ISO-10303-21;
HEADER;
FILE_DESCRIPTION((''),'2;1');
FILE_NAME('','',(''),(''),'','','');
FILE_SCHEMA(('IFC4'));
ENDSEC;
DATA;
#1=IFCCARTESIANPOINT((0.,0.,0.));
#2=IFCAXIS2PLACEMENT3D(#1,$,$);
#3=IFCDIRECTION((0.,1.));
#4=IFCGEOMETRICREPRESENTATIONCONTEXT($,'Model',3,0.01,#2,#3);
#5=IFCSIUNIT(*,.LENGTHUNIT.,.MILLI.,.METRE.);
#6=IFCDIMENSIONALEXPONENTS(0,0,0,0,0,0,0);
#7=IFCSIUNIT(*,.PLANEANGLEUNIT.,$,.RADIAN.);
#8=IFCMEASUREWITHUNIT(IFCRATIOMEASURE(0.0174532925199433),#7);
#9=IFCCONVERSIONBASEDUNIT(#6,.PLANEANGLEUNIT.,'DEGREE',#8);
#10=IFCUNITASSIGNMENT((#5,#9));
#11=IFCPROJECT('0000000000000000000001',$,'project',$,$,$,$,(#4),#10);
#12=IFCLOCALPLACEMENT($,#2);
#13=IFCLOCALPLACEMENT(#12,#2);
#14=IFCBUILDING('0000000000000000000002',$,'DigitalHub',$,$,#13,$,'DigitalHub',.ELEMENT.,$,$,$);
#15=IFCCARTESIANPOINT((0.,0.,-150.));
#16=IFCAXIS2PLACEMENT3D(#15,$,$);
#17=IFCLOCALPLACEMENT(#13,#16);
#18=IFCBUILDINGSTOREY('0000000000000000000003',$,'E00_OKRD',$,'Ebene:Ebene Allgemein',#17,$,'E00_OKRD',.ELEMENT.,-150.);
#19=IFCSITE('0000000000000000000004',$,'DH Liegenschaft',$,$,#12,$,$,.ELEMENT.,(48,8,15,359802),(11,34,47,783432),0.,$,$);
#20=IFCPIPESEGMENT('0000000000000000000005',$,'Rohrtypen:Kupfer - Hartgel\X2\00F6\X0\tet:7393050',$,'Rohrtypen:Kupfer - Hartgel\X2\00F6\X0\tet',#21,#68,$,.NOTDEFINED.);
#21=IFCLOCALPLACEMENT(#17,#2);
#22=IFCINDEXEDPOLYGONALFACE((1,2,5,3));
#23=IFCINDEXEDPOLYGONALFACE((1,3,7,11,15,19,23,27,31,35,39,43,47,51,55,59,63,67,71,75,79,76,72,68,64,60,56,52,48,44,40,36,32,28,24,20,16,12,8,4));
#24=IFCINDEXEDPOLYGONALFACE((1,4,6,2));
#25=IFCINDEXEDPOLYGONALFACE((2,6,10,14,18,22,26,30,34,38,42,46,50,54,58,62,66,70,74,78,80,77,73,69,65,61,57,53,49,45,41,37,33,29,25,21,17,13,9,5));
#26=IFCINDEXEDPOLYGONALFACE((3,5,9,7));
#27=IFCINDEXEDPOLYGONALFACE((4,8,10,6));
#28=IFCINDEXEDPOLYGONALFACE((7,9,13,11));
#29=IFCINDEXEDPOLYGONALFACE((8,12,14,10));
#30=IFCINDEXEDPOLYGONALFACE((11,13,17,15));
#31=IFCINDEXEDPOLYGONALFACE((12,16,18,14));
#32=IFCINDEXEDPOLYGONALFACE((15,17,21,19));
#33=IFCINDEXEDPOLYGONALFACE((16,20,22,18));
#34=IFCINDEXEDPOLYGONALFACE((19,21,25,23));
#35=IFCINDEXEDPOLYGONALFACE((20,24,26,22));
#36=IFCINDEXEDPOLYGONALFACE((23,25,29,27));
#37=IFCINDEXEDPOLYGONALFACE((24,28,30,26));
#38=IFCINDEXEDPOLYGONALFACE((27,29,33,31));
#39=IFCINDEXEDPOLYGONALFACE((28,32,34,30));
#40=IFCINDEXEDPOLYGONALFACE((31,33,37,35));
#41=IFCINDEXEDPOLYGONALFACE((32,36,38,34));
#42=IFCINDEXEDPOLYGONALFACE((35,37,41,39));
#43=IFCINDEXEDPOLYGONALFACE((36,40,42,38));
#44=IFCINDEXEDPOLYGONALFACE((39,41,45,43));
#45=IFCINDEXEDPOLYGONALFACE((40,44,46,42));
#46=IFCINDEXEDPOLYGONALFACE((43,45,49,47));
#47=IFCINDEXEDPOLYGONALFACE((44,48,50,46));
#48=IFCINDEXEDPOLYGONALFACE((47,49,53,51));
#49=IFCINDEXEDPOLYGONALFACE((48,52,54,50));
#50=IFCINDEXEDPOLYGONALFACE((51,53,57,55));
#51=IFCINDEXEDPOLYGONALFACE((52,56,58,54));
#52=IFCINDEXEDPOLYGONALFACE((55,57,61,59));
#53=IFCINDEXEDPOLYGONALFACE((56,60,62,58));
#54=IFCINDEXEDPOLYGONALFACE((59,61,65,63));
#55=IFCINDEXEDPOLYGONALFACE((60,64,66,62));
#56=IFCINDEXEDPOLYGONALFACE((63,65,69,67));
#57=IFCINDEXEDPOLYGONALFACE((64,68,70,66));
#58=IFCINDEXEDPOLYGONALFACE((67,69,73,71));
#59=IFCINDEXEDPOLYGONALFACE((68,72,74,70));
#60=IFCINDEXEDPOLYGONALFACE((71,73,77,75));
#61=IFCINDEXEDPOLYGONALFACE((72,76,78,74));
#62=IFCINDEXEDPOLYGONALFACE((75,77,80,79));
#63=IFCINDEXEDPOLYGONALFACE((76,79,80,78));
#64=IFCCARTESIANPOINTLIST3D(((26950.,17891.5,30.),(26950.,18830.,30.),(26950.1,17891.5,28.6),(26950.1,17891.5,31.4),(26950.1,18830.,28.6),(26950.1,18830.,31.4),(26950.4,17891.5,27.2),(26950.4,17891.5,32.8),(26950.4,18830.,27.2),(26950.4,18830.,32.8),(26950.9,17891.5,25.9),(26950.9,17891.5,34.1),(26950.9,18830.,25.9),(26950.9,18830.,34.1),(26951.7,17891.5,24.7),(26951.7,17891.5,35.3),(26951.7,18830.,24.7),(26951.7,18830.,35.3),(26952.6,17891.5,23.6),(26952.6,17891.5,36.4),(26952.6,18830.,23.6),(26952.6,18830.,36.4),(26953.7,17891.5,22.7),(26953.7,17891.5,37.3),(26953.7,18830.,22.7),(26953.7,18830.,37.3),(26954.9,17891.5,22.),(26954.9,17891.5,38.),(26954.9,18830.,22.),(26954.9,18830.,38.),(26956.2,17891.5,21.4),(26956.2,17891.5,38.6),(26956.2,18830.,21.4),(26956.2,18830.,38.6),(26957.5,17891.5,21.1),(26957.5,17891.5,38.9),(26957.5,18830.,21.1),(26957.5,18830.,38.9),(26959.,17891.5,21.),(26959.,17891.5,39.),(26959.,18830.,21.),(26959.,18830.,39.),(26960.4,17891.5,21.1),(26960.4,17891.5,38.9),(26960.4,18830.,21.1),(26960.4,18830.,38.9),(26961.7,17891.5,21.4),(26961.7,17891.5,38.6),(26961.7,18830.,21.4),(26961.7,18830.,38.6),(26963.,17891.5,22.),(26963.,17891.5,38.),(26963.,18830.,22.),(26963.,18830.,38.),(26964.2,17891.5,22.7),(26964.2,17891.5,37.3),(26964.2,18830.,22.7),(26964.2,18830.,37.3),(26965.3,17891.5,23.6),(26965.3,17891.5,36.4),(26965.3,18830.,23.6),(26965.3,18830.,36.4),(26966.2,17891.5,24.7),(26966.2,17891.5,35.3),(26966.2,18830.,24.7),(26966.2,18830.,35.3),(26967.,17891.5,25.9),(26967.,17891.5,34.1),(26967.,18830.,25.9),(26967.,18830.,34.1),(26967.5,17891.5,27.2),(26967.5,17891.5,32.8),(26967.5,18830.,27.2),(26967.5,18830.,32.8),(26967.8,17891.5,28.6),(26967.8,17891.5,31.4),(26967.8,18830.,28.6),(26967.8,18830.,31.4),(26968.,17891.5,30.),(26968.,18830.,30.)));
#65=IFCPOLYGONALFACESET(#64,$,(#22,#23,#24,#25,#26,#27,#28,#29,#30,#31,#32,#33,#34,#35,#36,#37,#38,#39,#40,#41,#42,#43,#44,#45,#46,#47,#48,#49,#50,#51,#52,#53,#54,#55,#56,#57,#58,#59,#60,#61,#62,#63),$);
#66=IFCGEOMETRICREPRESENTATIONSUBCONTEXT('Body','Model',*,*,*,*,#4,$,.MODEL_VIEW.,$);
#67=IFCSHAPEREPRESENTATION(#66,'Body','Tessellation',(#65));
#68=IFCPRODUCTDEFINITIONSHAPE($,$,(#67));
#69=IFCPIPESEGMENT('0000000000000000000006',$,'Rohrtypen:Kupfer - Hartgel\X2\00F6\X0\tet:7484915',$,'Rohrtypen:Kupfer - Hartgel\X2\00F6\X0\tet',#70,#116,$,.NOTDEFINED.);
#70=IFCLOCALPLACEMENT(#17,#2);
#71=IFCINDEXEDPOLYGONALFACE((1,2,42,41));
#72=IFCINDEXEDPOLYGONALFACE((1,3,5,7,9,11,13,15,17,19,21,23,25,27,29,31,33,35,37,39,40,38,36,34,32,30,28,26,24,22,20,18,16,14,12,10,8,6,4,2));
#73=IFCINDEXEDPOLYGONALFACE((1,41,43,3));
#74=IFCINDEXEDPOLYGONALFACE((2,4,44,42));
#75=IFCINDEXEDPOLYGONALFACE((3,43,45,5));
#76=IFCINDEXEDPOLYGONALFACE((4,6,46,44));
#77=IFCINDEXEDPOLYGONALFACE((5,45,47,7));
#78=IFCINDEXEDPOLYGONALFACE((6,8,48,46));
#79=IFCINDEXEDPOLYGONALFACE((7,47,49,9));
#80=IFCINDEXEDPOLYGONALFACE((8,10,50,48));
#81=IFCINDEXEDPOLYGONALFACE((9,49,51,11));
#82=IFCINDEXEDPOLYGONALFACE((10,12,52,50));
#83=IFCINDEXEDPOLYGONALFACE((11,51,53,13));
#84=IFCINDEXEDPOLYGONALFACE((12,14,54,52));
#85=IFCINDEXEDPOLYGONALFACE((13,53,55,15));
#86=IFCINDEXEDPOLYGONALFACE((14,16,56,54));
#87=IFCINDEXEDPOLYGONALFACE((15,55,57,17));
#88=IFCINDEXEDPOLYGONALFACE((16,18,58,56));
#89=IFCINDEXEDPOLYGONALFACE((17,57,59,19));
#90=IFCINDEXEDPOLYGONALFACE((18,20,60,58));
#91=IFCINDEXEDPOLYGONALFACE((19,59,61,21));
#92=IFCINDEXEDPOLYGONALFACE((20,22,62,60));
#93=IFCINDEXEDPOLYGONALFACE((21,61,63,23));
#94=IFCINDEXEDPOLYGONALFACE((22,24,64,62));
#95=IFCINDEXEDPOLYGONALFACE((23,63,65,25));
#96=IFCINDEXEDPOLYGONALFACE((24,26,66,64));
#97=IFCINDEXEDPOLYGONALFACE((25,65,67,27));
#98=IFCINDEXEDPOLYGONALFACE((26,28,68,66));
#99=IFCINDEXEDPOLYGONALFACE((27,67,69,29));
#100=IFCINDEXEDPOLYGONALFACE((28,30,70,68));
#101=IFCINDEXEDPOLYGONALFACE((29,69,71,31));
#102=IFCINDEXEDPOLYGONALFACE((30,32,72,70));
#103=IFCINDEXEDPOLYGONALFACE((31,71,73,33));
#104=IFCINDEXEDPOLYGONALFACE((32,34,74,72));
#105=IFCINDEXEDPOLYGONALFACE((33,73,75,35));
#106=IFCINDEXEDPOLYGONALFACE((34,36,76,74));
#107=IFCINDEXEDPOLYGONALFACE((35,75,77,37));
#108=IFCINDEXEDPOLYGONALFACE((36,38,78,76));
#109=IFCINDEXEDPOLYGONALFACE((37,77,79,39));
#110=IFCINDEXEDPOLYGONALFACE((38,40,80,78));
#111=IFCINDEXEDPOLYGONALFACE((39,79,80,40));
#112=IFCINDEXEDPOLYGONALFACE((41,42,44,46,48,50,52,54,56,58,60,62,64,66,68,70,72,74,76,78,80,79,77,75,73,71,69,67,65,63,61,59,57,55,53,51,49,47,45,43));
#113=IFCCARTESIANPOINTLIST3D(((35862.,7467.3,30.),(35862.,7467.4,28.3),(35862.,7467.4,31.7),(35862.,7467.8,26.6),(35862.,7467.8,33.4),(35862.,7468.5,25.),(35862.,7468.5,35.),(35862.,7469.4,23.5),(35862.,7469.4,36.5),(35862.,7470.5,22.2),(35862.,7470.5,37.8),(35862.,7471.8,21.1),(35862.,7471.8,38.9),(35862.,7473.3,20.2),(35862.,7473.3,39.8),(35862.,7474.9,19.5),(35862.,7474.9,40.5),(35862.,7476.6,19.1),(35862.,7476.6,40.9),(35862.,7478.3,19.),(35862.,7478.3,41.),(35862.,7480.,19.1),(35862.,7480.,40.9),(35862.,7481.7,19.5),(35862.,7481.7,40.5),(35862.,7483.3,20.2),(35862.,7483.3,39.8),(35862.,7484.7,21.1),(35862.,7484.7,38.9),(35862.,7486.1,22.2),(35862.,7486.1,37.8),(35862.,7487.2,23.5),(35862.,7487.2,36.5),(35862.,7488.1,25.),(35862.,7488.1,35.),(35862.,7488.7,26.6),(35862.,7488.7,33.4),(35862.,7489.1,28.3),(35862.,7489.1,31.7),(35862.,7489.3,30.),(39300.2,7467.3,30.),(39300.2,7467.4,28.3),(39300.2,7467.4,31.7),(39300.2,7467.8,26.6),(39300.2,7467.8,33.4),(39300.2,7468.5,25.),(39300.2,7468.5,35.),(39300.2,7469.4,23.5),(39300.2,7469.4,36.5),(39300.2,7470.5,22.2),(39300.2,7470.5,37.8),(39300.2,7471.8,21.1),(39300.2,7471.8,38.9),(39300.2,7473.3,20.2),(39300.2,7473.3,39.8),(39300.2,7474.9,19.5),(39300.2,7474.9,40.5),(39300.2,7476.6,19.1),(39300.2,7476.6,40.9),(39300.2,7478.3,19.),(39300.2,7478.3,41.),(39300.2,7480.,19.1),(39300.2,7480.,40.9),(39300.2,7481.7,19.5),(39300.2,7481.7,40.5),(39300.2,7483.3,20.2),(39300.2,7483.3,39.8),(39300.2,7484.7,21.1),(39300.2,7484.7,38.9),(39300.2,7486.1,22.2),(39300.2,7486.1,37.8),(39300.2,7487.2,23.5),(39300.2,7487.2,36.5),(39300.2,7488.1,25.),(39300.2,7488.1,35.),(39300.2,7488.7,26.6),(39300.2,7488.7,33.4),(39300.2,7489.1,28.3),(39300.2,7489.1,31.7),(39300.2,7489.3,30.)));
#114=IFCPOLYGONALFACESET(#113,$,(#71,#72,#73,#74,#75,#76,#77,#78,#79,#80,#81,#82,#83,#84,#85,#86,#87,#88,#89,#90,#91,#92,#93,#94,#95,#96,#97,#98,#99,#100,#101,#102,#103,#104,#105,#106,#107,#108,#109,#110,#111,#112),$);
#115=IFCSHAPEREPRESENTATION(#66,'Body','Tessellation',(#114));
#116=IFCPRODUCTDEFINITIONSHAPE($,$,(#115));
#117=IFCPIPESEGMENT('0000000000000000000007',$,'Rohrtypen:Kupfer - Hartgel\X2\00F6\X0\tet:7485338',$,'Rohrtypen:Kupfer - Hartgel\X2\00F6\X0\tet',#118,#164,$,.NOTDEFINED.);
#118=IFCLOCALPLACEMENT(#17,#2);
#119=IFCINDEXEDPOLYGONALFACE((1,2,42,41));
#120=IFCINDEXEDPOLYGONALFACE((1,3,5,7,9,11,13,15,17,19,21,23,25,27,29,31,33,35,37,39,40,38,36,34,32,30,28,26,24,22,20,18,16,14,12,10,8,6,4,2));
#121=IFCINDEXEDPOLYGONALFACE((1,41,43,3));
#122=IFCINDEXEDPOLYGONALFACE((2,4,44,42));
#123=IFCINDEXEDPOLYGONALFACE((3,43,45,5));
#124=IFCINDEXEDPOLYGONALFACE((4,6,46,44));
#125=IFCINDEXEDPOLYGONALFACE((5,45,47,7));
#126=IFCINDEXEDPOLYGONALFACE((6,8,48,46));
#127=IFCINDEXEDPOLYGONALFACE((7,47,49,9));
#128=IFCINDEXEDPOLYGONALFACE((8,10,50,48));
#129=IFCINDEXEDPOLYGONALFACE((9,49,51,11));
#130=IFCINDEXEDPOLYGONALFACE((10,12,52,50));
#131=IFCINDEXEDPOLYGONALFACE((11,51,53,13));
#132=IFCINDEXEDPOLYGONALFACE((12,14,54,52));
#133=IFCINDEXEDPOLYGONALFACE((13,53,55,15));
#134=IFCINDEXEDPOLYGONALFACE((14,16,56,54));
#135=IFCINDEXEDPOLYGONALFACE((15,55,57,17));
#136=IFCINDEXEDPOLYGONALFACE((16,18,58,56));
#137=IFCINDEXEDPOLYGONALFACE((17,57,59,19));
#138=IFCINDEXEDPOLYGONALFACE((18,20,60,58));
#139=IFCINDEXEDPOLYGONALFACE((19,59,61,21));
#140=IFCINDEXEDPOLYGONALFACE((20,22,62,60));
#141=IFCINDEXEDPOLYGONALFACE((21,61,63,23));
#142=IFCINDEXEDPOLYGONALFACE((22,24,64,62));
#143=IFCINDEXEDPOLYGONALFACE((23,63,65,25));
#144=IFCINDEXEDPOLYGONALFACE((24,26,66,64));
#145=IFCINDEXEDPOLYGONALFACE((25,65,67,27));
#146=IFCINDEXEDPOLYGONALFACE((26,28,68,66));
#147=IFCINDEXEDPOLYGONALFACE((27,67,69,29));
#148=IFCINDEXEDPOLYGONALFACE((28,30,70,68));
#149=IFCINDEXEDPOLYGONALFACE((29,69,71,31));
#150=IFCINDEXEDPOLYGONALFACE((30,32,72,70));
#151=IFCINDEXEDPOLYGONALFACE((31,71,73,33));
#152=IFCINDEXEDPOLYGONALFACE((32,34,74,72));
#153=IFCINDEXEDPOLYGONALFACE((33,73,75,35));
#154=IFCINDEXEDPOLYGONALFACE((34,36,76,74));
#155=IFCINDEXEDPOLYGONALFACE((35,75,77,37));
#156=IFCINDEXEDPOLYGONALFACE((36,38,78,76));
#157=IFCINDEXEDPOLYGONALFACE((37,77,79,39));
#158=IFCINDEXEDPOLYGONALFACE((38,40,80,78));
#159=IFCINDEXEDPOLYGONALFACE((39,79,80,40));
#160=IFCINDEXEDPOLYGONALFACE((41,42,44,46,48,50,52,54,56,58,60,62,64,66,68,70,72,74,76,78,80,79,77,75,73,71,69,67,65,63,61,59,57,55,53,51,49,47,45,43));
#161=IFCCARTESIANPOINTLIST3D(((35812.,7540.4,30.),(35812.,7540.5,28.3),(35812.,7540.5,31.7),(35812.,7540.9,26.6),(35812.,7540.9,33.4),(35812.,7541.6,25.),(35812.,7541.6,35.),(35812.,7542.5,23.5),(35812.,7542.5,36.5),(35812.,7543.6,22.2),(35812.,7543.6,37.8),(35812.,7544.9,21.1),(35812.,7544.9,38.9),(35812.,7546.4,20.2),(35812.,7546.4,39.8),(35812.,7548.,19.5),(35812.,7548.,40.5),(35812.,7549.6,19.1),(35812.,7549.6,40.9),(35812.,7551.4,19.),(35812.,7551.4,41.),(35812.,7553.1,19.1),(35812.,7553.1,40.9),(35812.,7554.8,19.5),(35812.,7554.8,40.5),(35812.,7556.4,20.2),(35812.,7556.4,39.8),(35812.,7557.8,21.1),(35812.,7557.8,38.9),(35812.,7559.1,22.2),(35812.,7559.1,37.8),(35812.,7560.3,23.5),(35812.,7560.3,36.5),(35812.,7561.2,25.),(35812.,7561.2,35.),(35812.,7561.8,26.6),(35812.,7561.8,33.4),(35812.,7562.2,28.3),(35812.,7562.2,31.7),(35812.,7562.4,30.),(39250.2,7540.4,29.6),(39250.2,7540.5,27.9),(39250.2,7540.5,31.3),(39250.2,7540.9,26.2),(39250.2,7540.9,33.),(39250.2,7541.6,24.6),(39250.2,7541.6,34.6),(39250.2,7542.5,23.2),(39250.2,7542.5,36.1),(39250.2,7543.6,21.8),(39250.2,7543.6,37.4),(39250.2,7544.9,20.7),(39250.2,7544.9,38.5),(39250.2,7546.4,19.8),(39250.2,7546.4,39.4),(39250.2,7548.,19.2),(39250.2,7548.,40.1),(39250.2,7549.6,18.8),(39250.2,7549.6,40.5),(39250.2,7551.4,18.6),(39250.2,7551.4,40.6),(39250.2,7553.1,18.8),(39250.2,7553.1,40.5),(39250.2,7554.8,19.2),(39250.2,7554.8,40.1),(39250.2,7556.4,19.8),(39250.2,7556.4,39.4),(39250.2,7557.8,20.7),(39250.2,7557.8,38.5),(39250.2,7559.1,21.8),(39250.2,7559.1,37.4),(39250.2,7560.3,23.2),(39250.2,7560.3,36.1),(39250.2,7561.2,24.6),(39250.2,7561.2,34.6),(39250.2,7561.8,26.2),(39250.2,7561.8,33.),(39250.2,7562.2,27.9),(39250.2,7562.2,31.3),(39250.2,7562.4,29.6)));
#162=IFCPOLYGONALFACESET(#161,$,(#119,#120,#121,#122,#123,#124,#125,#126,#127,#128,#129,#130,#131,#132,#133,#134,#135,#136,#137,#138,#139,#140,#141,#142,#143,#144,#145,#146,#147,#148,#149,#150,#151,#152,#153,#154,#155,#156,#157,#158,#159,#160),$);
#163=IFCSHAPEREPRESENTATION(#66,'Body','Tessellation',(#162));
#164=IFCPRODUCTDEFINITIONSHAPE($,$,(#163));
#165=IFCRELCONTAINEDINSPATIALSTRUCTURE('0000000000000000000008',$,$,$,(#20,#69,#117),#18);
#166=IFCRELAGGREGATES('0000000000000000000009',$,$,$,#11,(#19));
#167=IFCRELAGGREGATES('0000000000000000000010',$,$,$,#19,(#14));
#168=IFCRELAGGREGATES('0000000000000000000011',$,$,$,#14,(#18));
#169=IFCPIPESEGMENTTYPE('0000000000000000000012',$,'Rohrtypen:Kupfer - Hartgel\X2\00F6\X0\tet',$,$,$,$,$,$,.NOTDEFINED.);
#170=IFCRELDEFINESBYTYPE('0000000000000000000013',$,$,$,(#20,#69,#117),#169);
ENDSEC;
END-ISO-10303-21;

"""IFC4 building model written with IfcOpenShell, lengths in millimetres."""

from ifc_helpers import new_model, entity, si_unit, converted_unit, direction, frame, origin, place, context, subcontext, project, spatial, indexed_curve, outline, extrude, type_object, element, save


model = new_model("IFC4")

# Units and contexts
model_context = context("Model", 3, precision=0.01, world=origin(), true_north=direction((0.0, 1.0)))
body_context = subcontext(model_context, "Body", "Model", "MODEL_VIEW")
ifc_project = project(units=[si_unit("LENGTHUNIT", "METRE", prefix="MILLI"), converted_unit("PLANEANGLEUNIT", "DEGREE", entity("IfcRatioMeasure", 0.0174532925199433), si_unit("PLANEANGLEUNIT", "RADIAN"), dimensions=[0, 0, 0, 0, 0, 0, 0])], contexts=[model_context])

# Site, building, storey
site_placement = place(None, origin())
site = spatial("IfcSite", under=ifc_project, at=site_placement, Name="DH Liegenschaft", CompositionType="ELEMENT", RefLatitude=(48, 8, 15, 359802), RefLongitude=(11, 34, 47, 783432), RefElevation=0.0)
building_placement = place(site_placement, origin())
building = spatial("IfcBuilding", under=site, at=building_placement, Name="DigitalHub", LongName="DigitalHub", CompositionType="ELEMENT")
storey_placement = place(building_placement, frame((0.0, 0.0, -150.0)))
storey = spatial("IfcBuildingStorey", under=building, at=storey_placement, Name="E00_OKRD", ObjectType="Ebene:Ebene Allgemein", LongName="E00_OKRD", CompositionType="ELEMENT", Elevation=-150.0)

# Pipe segments
pipe_segment_type = type_object("IfcPipeSegmentType", Name="Rohrtypen:Kupfer - Hartgelötet", PredefinedType="NOTDEFINED")
pipe_segment_1_placement = place(storey_placement, frame((26948.4, 17891.5, 19.4)))
element("IfcPipeSegment", 1, at=pipe_segment_1_placement, inside=storey, type_object=pipe_segment_type, Name="Rohrtypen:Kupfer - Hartgelötet:7393050", ObjectType="Rohrtypen:Kupfer - Hartgelötet", PredefinedType="NOTDEFINED", context=body_context, shape_type="SweptSolid", body=[
    extrude(outline(indexed_curve([(9.0, 0.0), (8.9, 1.4), (8.6, 2.8), (8.0, 4.1), (7.3, 5.3), (6.4, 6.4), (5.3, 7.3), (4.1, 8.0), (2.8, 8.6), (1.4, 8.9), (0.0, 9.0), (-1.4, 8.9), (-2.8, 8.6), (-4.1, 8.0), (-5.3, 7.3), (-6.4, 6.4), (-7.3, 5.3), (-8.0, 4.1), (-8.6, 2.8), (-8.9, 1.4), (-9.0, 0.0), (-8.9, -1.4), (-8.6, -2.8), (-8.0, -4.1), (-7.3, -5.3), (-6.4, -6.4), (-5.3, -7.3), (-4.1, -8.0), (-2.8, -8.6), (-1.4, -8.9), (0.0, -9.0), (1.4, -8.9), (2.8, -8.6), (4.1, -8.0), (5.3, -7.3), (6.4, -6.4), (7.3, -5.3), (8.0, -4.1), (8.6, -2.8), (8.9, -1.4), (9.0, 0.0)], self_intersect=False)), frame((10.6, 0.0, 10.6), z_axis=(0.0, 1.0, 0.0), x_axis=(1.0, 0.0, 0.0)), (0.0, 0.0, 1.0), 938.4),
])
pipe_segment_2_placement = place(storey_placement, frame((35862.0, 7465.7, 17.4)))
element("IfcPipeSegment", 2, at=pipe_segment_2_placement, inside=storey, type_object=pipe_segment_type, Name="Rohrtypen:Kupfer - Hartgelötet:7484915", ObjectType="Rohrtypen:Kupfer - Hartgelötet", PredefinedType="NOTDEFINED", context=body_context, shape_type="SweptSolid", body=[
    extrude(outline(indexed_curve([(11.0, 0.0), (10.9, 1.7), (10.5, 3.4), (9.8, 5.0), (8.9, 6.5), (7.8, 7.8), (6.5, 8.9), (5.0, 9.8), (3.4, 10.5), (1.7, 10.9), (0.0, 11.0), (-1.7, 10.9), (-3.4, 10.5), (-5.0, 9.8), (-6.5, 8.9), (-7.8, 7.8), (-8.9, 6.5), (-9.8, 5.0), (-10.5, 3.4), (-10.9, 1.7), (-11.0, 0.0), (-10.9, -1.7), (-10.5, -3.4), (-9.8, -5.0), (-8.9, -6.5), (-7.8, -7.8), (-6.5, -8.9), (-5.0, -9.8), (-3.4, -10.5), (-1.7, -10.9), (0.0, -11.0), (1.7, -10.9), (3.4, -10.5), (5.0, -9.8), (6.5, -8.9), (7.8, -7.8), (8.9, -6.5), (9.8, -5.0), (10.5, -3.4), (10.9, -1.7), (11.0, 0.0)], self_intersect=False)), frame((0.0, 12.6, 12.6), z_axis=(1.0, 0.0, 0.0), x_axis=(0.0, -1.0, 0.0)), (0.0, 0.0, 1.0), 3438.2),
])
pipe_segment_3_placement = place(storey_placement, frame((35812.0, 7538.8, 17.0)))
element("IfcPipeSegment", 3, at=pipe_segment_3_placement, inside=storey, type_object=pipe_segment_type, Name="Rohrtypen:Kupfer - Hartgelötet:7485338", ObjectType="Rohrtypen:Kupfer - Hartgelötet", PredefinedType="NOTDEFINED", context=body_context, shape_type="SweptSolid", body=[
    extrude(outline(indexed_curve([(11.0, 0.0), (10.9, 1.7), (10.5, 3.4), (9.8, 5.0), (8.9, 6.5), (7.8, 7.8), (6.5, 8.9), (5.0, 9.8), (3.4, 10.5), (1.7, 10.9), (0.0, 11.0), (-1.7, 10.9), (-3.4, 10.5), (-5.0, 9.8), (-6.5, 8.9), (-7.8, 7.8), (-8.9, 6.5), (-9.8, 5.0), (-10.5, 3.4), (-10.9, 1.7), (-11.0, 0.0), (-10.9, -1.7), (-10.5, -3.4), (-9.8, -5.0), (-8.9, -6.5), (-7.8, -7.8), (-6.5, -8.9), (-5.0, -9.8), (-3.4, -10.5), (-1.7, -10.9), (0.0, -11.0), (1.7, -10.9), (3.4, -10.5), (5.0, -9.8), (6.5, -8.9), (7.8, -7.8), (8.9, -6.5), (9.8, -5.0), (10.5, -3.4), (10.9, -1.7), (11.0, 0.0)], self_intersect=False)), frame((3438.2, 12.6, 12.6), z_axis=(-1.0, 0.0, 0.000111), x_axis=(0.0, 1.0, 0.0)), (0.0, 0.0, 1.0), 3438.2),
])

save(model, "model.ifc")
